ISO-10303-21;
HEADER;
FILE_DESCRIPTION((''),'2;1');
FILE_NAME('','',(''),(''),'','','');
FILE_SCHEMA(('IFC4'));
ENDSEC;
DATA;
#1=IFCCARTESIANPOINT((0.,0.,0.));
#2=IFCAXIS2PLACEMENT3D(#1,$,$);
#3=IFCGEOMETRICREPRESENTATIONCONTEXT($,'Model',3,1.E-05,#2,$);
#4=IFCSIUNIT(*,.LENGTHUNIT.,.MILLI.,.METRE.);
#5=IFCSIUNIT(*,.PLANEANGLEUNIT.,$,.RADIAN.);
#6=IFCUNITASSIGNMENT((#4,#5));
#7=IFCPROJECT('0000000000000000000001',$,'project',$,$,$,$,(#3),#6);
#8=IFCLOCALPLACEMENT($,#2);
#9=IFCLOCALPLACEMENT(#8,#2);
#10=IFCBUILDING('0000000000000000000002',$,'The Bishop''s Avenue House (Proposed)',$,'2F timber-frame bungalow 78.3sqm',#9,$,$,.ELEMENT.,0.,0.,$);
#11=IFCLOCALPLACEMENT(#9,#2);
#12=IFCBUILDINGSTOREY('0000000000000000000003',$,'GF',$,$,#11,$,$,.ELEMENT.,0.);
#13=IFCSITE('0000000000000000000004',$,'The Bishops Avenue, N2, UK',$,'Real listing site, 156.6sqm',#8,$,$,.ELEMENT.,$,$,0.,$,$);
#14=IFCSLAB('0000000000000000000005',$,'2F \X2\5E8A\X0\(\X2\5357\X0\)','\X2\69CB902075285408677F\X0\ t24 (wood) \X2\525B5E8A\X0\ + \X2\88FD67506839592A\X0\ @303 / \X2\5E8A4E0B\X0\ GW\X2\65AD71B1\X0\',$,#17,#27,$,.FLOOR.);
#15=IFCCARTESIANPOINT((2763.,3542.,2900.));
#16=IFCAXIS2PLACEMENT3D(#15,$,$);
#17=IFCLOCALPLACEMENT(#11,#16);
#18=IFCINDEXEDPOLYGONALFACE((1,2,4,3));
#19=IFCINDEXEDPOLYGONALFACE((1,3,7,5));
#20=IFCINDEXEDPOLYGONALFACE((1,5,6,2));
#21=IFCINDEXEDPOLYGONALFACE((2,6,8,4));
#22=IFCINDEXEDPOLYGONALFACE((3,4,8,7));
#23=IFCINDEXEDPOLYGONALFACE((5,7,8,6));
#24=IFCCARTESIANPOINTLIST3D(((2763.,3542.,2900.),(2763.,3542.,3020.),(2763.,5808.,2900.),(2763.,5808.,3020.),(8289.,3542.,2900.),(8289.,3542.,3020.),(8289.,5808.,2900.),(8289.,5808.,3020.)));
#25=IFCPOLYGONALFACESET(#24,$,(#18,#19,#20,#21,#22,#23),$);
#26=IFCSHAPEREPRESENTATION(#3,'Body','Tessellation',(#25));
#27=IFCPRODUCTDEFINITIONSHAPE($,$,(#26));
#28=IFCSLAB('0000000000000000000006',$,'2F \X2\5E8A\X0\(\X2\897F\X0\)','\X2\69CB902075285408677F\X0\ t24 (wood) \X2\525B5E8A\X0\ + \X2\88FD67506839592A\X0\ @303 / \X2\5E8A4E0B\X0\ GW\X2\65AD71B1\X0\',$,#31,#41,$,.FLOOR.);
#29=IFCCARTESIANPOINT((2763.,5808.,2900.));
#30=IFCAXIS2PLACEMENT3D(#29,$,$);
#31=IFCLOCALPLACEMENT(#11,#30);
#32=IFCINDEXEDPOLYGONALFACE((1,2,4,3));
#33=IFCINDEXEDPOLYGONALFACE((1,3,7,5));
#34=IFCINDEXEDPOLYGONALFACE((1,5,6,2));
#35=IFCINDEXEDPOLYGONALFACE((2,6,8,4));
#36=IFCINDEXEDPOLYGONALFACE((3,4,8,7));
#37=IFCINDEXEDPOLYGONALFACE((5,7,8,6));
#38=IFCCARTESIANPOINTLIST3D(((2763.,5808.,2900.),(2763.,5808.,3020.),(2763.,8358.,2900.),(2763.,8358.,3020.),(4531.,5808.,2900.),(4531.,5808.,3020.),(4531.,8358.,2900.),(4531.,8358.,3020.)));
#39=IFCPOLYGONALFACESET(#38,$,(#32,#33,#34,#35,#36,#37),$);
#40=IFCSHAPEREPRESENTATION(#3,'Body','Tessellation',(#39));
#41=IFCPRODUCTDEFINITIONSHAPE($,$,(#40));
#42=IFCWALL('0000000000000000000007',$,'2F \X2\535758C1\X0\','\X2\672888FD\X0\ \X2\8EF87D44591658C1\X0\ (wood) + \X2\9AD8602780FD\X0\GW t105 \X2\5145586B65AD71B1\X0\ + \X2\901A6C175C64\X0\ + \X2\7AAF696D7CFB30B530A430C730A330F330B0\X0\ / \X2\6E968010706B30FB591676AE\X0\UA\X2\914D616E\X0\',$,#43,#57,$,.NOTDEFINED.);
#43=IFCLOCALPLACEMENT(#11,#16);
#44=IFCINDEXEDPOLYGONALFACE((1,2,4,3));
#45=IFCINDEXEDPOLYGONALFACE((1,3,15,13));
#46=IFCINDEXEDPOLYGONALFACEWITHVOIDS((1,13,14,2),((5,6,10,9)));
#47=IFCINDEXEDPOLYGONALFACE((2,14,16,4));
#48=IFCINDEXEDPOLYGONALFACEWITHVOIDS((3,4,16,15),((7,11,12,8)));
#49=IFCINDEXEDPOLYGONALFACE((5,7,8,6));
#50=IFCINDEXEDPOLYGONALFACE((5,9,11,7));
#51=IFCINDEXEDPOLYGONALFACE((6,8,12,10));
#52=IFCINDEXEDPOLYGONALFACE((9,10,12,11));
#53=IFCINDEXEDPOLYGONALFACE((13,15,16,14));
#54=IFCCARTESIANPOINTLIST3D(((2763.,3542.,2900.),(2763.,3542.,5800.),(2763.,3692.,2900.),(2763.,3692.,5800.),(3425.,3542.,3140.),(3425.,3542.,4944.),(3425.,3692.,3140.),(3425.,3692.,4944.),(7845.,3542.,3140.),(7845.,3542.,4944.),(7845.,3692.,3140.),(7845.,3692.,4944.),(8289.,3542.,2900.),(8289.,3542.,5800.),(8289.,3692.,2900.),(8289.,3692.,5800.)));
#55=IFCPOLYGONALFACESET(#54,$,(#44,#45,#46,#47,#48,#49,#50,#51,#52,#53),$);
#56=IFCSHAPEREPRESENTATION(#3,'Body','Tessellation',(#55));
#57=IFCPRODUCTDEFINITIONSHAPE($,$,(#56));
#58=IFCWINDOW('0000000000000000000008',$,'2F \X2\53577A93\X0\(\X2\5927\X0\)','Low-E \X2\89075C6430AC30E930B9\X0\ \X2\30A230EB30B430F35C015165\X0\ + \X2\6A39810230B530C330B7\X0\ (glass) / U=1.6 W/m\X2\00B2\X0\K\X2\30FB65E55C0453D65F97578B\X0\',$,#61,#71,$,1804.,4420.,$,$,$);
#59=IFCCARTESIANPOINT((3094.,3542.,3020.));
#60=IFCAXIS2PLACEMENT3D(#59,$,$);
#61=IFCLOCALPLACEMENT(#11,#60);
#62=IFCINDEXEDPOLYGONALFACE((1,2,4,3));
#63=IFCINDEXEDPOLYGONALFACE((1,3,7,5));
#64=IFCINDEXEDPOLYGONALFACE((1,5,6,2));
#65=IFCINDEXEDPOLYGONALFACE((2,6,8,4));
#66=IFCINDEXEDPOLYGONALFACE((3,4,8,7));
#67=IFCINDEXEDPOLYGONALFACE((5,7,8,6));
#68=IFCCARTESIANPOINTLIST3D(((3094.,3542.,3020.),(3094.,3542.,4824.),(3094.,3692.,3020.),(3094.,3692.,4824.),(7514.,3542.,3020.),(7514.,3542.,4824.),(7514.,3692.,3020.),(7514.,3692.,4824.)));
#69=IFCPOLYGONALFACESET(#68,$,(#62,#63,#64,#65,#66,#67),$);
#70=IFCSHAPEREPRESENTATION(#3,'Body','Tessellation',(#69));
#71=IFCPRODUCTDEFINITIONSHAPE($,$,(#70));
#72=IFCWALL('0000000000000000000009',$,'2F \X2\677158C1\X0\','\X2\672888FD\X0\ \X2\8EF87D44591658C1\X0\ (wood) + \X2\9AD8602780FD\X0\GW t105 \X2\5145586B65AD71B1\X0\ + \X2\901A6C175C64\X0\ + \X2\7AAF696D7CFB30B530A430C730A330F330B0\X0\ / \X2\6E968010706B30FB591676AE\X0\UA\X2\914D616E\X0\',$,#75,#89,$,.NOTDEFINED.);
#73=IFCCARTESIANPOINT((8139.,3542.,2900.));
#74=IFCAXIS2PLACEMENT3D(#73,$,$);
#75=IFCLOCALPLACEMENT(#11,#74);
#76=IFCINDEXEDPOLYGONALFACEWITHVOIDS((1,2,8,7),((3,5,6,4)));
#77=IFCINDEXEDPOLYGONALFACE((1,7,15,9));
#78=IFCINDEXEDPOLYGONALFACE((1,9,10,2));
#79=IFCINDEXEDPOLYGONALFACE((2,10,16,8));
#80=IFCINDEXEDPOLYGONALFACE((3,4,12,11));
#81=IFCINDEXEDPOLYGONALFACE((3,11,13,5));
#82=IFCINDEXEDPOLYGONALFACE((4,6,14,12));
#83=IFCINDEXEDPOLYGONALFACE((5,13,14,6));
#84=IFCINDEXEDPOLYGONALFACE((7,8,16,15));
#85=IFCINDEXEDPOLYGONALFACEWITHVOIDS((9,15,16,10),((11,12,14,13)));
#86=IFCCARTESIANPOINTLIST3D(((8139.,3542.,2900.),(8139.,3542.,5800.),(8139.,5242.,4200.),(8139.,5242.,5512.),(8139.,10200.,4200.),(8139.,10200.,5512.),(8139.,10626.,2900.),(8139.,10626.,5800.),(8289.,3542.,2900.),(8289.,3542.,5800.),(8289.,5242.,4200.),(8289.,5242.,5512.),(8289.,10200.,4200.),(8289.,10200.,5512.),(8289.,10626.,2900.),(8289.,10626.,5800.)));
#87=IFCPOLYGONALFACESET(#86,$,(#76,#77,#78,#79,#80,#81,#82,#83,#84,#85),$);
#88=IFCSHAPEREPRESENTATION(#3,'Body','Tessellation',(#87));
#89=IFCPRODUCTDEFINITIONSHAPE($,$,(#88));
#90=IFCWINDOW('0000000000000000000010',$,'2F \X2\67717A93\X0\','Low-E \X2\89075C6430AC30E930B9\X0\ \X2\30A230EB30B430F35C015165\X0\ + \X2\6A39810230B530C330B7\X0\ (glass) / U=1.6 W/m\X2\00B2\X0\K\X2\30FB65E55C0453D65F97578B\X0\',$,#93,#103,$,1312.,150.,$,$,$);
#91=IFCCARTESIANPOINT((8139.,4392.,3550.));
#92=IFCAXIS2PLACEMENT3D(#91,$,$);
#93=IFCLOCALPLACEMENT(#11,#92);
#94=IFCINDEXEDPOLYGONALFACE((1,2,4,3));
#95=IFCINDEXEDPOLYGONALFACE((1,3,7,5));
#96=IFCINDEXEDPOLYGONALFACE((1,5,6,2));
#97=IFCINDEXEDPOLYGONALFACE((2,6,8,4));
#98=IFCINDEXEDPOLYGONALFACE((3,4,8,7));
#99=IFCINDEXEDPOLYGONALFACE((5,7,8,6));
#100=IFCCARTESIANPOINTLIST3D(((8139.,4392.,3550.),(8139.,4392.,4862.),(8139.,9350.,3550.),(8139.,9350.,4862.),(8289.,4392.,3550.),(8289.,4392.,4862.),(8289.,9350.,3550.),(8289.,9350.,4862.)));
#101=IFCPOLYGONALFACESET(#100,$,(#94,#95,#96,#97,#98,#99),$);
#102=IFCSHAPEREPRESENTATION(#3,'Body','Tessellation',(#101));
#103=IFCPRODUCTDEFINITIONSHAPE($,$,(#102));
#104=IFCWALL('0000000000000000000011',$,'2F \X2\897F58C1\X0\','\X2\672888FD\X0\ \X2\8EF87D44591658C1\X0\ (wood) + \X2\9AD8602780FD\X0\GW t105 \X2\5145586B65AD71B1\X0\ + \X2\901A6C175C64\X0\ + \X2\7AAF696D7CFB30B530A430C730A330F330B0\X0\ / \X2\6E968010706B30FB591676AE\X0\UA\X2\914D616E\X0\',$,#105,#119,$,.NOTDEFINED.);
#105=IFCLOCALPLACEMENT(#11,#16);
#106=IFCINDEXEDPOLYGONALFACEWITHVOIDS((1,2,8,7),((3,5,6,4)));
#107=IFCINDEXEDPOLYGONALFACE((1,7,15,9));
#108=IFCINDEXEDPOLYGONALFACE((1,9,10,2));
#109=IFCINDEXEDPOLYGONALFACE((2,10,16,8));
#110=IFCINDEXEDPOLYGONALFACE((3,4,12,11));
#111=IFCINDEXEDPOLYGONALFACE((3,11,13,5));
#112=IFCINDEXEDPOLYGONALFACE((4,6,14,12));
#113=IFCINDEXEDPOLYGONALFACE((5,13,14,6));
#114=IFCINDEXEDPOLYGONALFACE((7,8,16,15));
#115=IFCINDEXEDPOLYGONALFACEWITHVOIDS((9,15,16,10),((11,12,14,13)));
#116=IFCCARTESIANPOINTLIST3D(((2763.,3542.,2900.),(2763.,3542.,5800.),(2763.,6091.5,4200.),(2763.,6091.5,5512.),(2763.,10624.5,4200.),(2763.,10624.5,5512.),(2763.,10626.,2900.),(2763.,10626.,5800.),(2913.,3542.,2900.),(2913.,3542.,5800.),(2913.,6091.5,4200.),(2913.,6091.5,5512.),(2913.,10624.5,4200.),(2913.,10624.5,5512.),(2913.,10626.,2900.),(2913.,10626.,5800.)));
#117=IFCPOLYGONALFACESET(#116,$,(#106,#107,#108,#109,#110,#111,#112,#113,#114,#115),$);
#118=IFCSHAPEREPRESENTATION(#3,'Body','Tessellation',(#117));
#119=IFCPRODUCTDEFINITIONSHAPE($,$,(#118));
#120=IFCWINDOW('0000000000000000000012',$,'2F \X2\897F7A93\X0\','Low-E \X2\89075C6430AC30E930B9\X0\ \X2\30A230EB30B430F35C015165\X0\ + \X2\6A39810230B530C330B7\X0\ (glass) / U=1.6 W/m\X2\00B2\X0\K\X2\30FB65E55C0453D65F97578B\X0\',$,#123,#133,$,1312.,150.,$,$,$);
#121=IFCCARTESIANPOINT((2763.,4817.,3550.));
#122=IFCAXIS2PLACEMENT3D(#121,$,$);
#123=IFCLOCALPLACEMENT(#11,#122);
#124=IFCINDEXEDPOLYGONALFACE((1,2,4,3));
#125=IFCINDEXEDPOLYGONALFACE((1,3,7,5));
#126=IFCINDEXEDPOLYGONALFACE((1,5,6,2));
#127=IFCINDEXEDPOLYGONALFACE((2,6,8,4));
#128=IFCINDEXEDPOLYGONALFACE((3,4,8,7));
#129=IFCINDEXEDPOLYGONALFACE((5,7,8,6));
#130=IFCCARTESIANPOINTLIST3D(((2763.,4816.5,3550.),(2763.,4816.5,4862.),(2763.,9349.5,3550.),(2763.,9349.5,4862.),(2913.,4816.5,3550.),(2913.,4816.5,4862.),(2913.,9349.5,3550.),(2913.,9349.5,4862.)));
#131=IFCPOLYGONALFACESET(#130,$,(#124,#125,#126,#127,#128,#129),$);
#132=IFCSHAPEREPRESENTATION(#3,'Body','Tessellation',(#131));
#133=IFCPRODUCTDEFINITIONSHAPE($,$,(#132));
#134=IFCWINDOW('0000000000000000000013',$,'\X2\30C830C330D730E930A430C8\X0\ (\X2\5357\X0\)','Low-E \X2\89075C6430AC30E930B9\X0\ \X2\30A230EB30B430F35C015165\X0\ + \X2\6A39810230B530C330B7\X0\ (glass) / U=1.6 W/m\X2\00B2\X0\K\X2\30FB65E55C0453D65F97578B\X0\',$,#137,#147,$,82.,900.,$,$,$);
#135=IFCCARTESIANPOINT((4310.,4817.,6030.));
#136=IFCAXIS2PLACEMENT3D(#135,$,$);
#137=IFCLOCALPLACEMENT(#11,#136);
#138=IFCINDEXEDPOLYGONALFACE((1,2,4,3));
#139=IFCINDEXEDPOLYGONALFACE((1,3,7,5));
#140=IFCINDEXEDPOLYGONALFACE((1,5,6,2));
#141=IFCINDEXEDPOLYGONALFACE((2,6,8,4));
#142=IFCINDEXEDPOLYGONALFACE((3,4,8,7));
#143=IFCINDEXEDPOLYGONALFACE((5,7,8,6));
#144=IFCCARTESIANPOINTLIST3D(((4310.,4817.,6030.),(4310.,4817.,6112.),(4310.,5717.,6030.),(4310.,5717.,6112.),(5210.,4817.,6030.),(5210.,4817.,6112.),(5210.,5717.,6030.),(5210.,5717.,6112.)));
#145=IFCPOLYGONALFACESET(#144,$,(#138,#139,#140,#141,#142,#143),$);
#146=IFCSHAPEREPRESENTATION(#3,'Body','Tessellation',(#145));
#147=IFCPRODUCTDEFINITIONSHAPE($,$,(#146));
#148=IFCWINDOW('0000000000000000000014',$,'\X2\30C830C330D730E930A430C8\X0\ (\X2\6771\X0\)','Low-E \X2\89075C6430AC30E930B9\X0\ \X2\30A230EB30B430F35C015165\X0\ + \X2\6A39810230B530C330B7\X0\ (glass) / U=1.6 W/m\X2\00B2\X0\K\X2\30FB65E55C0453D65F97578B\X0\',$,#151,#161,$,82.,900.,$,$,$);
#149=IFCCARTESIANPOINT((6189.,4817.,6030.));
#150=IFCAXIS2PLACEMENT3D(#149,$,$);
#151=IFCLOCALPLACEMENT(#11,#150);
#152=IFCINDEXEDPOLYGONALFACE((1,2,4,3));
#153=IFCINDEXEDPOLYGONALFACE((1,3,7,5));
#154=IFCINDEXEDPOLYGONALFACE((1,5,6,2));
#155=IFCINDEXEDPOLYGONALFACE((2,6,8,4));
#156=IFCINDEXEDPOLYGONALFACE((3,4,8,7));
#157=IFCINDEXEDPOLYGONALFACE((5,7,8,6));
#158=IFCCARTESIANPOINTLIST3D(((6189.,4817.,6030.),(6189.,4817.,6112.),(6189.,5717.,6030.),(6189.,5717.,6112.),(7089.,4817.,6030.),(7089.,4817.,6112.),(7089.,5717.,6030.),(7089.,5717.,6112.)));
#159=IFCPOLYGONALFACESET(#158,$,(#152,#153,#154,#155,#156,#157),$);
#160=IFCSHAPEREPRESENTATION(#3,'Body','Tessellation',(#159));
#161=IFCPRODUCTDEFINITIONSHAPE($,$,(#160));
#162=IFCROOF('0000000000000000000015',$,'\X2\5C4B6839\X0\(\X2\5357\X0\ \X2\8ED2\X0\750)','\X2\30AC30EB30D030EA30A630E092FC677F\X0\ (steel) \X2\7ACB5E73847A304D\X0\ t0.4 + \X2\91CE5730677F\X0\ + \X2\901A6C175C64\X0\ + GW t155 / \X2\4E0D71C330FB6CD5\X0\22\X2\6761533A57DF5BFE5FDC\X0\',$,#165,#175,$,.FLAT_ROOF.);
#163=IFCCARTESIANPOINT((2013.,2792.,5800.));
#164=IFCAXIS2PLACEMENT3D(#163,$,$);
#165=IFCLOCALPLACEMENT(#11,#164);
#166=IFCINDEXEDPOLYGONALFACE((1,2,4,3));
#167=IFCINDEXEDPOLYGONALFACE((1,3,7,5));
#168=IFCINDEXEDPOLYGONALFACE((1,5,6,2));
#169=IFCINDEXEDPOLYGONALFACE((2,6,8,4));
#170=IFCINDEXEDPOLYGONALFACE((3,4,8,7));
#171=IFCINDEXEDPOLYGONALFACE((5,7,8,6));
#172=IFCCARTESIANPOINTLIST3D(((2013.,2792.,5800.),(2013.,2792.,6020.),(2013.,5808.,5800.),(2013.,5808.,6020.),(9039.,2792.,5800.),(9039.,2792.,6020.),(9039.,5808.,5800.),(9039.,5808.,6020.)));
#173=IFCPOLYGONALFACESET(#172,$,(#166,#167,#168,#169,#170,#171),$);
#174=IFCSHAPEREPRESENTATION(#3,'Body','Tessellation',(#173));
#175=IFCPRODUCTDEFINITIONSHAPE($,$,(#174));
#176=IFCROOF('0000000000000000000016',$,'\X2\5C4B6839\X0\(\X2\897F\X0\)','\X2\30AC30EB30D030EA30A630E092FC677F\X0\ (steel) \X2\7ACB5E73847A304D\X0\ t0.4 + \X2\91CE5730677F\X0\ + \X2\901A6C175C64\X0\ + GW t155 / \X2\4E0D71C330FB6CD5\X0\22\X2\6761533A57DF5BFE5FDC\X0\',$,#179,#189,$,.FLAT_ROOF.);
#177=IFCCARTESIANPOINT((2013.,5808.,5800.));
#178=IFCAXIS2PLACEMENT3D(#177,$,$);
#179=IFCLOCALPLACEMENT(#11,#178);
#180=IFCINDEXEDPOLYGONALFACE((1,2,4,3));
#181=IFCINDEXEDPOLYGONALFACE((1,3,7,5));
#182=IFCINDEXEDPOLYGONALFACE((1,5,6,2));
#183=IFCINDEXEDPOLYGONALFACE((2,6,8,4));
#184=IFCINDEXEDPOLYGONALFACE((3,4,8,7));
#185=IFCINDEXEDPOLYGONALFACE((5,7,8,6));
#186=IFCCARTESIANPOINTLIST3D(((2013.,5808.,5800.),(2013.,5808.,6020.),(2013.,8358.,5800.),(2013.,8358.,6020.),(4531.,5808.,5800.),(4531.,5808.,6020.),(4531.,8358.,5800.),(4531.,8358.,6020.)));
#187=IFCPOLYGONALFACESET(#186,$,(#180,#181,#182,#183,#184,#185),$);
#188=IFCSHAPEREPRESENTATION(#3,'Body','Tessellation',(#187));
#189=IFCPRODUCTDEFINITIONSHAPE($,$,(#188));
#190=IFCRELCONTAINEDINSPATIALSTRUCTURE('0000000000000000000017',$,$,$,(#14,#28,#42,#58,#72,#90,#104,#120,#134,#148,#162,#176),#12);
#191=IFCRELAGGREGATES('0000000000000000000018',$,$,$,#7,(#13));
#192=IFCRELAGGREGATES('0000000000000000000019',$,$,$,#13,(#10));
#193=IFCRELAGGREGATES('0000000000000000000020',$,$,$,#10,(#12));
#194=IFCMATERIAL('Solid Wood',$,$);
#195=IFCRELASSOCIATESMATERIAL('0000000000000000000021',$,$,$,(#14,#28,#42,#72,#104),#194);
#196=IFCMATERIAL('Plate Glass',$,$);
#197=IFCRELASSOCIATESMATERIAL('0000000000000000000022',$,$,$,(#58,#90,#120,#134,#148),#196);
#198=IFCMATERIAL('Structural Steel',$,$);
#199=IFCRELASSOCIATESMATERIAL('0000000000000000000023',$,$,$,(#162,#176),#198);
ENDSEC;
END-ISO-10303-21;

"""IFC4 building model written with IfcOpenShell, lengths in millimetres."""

from ifc_helpers import new_model, si_unit, frame, frame_2d, origin, place, context, project, spatial, rectangle, extrude, material, element, fill, save


model = new_model("IFC4")

# Units and contexts
model_context = context("Model", 3, precision=1e-05, world=origin())
ifc_project = project(units=[si_unit("LENGTHUNIT", "METRE", prefix="MILLI"), si_unit("PLANEANGLEUNIT", "RADIAN")], contexts=[model_context])

# Site, building, storey
site_placement = place(None, origin())
site = spatial("IfcSite", under=ifc_project, at=site_placement, Name="The Bishops Avenue, N2, UK", ObjectType="Real listing site, 156.6sqm", CompositionType="ELEMENT", RefElevation=0.0)
building_placement = place(site_placement, origin())
building = spatial("IfcBuilding", under=site, at=building_placement, Name="The Bishop's Avenue House (Proposed)", ObjectType="2F timber-frame bungalow 78.3sqm", CompositionType="ELEMENT", ElevationOfRefHeight=0.0, ElevationOfTerrain=0.0)
storey_placement = place(building_placement, origin())
storey = spatial("IfcBuildingStorey", under=building, at=storey_placement, Name="GF", CompositionType="ELEMENT", Elevation=0.0)

# Slabs
ifc_material_1 = material(Name="Solid Wood")
slab_1_placement = place(storey_placement, frame((2763.0, 3542.0, 2900.0)))
element("IfcSlab", 1, at=slab_1_placement, inside=storey, material=ifc_material_1, Name="2F 床(南)", Description="構造用合板 t24 (wood) 剛床 + 製材根太 @303 / 床下 GW断熱", PredefinedType="FLOOR", context=model_context, shape_type="SweptSolid", body=[
    extrude(rectangle(XDim=5526.0, YDim=2266.0, at=frame_2d((2763.0, 1133.0))), frame((2763.0, 3542.0, 2900.0)), (0.0, 0.0, 1.0), 120.0),
])
slab_2_placement = place(storey_placement, frame((2763.0, 5808.0, 2900.0)))
element("IfcSlab", 2, at=slab_2_placement, inside=storey, material=ifc_material_1, Name="2F 床(西)", Description="構造用合板 t24 (wood) 剛床 + 製材根太 @303 / 床下 GW断熱", PredefinedType="FLOOR", context=model_context, shape_type="SweptSolid", body=[
    extrude(rectangle(XDim=1768.0, YDim=2550.0, at=frame_2d((884.0, 1275.0))), frame((2763.0, 5808.0, 2900.0)), (0.0, 0.0, 1.0), 120.0),
])

# Walls, openings, windows
wall_1_placement = place(storey_placement, frame((2763.0, 3542.0, 2900.0)))
wall_1 = element("IfcWall", 3, at=wall_1_placement, inside=storey, material=ifc_material_1, Name="2F 南壁", Description="木製 軸組外壁 (wood) + 高性能GW t105 充填断熱 + 通気層 + 窯業系サイディング / 準耐火・外皮UA配慮", PredefinedType="NOTDEFINED", context=model_context, shape_type="SweptSolid", body=[
    extrude(rectangle(XDim=5526.0, YDim=150.0, at=frame_2d((2763.0, 75.0))), frame((2763.0, 3542.0, 2900.0)), (0.0, 0.0, 1.0), 2900.0),
])
opening_1_placement = place(storey_placement, frame((3094.0, 3542.0, 3020.0)))
opening_1 = element("IfcOpeningElement", 4, at=opening_1_placement, cuts=wall_1, PredefinedType="NOTDEFINED", context=model_context, shape_type="SweptSolid", body=[
    extrude(rectangle(XDim=4420.0, YDim=150.0, at=frame_2d((2210.0, 75.0))), frame((3094.0, 3542.0, 3020.0)), (0.0, 0.0, 1.0), 1804.0),
])
ifc_material_2 = material(Name="Plate Glass")
window_1_placement = place(storey_placement, frame((3094.0, 3542.0, 3020.0)))
window_1 = element("IfcWindow", 5, at=window_1_placement, inside=storey, material=ifc_material_2, Name="2F 南窓(大)", Description="Low-E 複層ガラス アルゴン封入 + 樹脂サッシ (glass) / U=1.6 W/m²K・日射取得型", OverallHeight=1804.0, OverallWidth=4420.0, context=model_context, shape_type="SweptSolid", body=[
    extrude(rectangle(XDim=4420.0, YDim=150.0, at=frame_2d((2210.0, 75.0))), frame((3094.0, 3542.0, 3020.0)), (0.0, 0.0, 1.0), 1804.0),
])
fill(opening_1, window_1)
wall_2_placement = place(storey_placement, frame((8139.0, 3542.0, 2900.0)))
wall_2 = element("IfcWall", 6, at=wall_2_placement, inside=storey, material=ifc_material_1, Name="2F 東壁", Description="木製 軸組外壁 (wood) + 高性能GW t105 充填断熱 + 通気層 + 窯業系サイディング / 準耐火・外皮UA配慮", PredefinedType="NOTDEFINED", context=model_context, shape_type="SweptSolid", body=[
    extrude(rectangle(XDim=150.0, YDim=7084.0, at=frame_2d((75.0, 3542.0))), frame((8139.0, 3542.0, 2900.0)), (0.0, 0.0, 1.0), 2900.0),
])
opening_2_placement = place(storey_placement, frame((8139.0, 4392.0, 3550.0)))
opening_2 = element("IfcOpeningElement", 7, at=opening_2_placement, cuts=wall_2, PredefinedType="NOTDEFINED", context=model_context, shape_type="SweptSolid", body=[
    extrude(rectangle(XDim=150.0, YDim=4958.0, at=frame_2d((75.0, 2479.0))), frame((8139.0, 4392.0, 3550.0)), (0.0, 0.0, 1.0), 1312.0),
])
window_2_placement = place(storey_placement, frame((8139.0, 4392.0, 3550.0)))
window_2 = element("IfcWindow", 8, at=window_2_placement, inside=storey, material=ifc_material_2, Name="2F 東窓", Description="Low-E 複層ガラス アルゴン封入 + 樹脂サッシ (glass) / U=1.6 W/m²K・日射取得型", OverallHeight=1312.0, OverallWidth=150.0, context=model_context, shape_type="SweptSolid", body=[
    extrude(rectangle(XDim=150.0, YDim=4958.0, at=frame_2d((75.0, 2479.0))), frame((8139.0, 4392.0, 3550.0)), (0.0, 0.0, 1.0), 1312.0),
])
fill(opening_2, window_2)
wall_3_placement = place(storey_placement, frame((2763.0, 3542.0, 2900.0)))
wall_3 = element("IfcWall", 9, at=wall_3_placement, inside=storey, material=ifc_material_1, Name="2F 西壁", Description="木製 軸組外壁 (wood) + 高性能GW t105 充填断熱 + 通気層 + 窯業系サイディング / 準耐火・外皮UA配慮", PredefinedType="NOTDEFINED", context=model_context, shape_type="SweptSolid", body=[
    extrude(rectangle(XDim=150.0, YDim=7084.0, at=frame_2d((75.0, 3542.0))), frame((2763.0, 3542.0, 2900.0)), (0.0, 0.0, 1.0), 2900.0),
])
opening_3_placement = place(storey_placement, frame((2763.0, 4817.0, 3550.0)))
opening_3 = element("IfcOpeningElement", 10, at=opening_3_placement, cuts=wall_3, PredefinedType="NOTDEFINED", context=model_context, shape_type="SweptSolid", body=[
    extrude(rectangle(XDim=150.0, YDim=4533.0, at=frame_2d((75.0, 2266.0))), frame((2763.0, 4817.0, 3550.0)), (0.0, 0.0, 1.0), 1312.0),
])
window_3_placement = place(storey_placement, frame((2763.0, 4817.0, 3550.0)))
window_3 = element("IfcWindow", 11, at=window_3_placement, inside=storey, material=ifc_material_2, Name="2F 西窓", Description="Low-E 複層ガラス アルゴン封入 + 樹脂サッシ (glass) / U=1.6 W/m²K・日射取得型", OverallHeight=1312.0, OverallWidth=150.0, context=model_context, shape_type="SweptSolid", body=[
    extrude(rectangle(XDim=150.0, YDim=4533.0, at=frame_2d((75.0, 2266.0))), frame((2763.0, 4817.0, 3550.0)), (0.0, 0.0, 1.0), 1312.0),
])
fill(opening_3, window_3)

# Windows
window_4_placement = place(storey_placement, frame((4310.0, 4817.0, 6030.0)))
element("IfcWindow", 12, at=window_4_placement, inside=storey, material=ifc_material_2, Name="トップライト (南)", Description="Low-E 複層ガラス アルゴン封入 + 樹脂サッシ (glass) / U=1.6 W/m²K・日射取得型", OverallHeight=82.0, OverallWidth=900.0, context=model_context, shape_type="SweptSolid", body=[
    extrude(rectangle(XDim=900.0, YDim=900.0, at=frame_2d((450.0, 450.0))), frame((4310.0, 4817.0, 6030.0)), (0.0, 0.0, 1.0), 82.0),
])
window_5_placement = place(storey_placement, frame((6189.0, 4817.0, 6030.0)))
element("IfcWindow", 13, at=window_5_placement, inside=storey, material=ifc_material_2, Name="トップライト (東)", Description="Low-E 複層ガラス アルゴン封入 + 樹脂サッシ (glass) / U=1.6 W/m²K・日射取得型", OverallHeight=82.0, OverallWidth=900.0, context=model_context, shape_type="SweptSolid", body=[
    extrude(rectangle(XDim=900.0, YDim=900.0, at=frame_2d((450.0, 450.0))), frame((6189.0, 4817.0, 6030.0)), (0.0, 0.0, 1.0), 82.0),
])

# Roofs
ifc_material_3 = material(Name="Structural Steel")
roof_1_placement = place(storey_placement, frame((2013.0, 2792.0, 5800.0)))
element("IfcRoof", 14, at=roof_1_placement, inside=storey, material=ifc_material_3, Name="屋根(南 軒750)", Description="ガルバリウム鋼板 (steel) 立平葺き t0.4 + 野地板 + 通気層 + GW t155 / 不燃・法22条区域対応", PredefinedType="FLAT_ROOF", context=model_context, shape_type="SweptSolid", body=[
    extrude(rectangle(XDim=7026.0, YDim=3016.0, at=frame_2d((3513.0, 1508.0))), frame((2013.0, 2792.0, 5800.0)), (0.0, 0.0, 1.0), 220.0),
])
roof_2_placement = place(storey_placement, frame((2013.0, 5808.0, 5800.0)))
element("IfcRoof", 15, at=roof_2_placement, inside=storey, material=ifc_material_3, Name="屋根(西)", Description="ガルバリウム鋼板 (steel) 立平葺き t0.4 + 野地板 + 通気層 + GW t155 / 不燃・法22条区域対応", PredefinedType="FLAT_ROOF", context=model_context, shape_type="SweptSolid", body=[
    extrude(rectangle(XDim=2518.0, YDim=2550.0, at=frame_2d((1259.0, 1275.0))), frame((2013.0, 5808.0, 5800.0)), (0.0, 0.0, 1.0), 220.0),
])

save(model, "model.ifc")
